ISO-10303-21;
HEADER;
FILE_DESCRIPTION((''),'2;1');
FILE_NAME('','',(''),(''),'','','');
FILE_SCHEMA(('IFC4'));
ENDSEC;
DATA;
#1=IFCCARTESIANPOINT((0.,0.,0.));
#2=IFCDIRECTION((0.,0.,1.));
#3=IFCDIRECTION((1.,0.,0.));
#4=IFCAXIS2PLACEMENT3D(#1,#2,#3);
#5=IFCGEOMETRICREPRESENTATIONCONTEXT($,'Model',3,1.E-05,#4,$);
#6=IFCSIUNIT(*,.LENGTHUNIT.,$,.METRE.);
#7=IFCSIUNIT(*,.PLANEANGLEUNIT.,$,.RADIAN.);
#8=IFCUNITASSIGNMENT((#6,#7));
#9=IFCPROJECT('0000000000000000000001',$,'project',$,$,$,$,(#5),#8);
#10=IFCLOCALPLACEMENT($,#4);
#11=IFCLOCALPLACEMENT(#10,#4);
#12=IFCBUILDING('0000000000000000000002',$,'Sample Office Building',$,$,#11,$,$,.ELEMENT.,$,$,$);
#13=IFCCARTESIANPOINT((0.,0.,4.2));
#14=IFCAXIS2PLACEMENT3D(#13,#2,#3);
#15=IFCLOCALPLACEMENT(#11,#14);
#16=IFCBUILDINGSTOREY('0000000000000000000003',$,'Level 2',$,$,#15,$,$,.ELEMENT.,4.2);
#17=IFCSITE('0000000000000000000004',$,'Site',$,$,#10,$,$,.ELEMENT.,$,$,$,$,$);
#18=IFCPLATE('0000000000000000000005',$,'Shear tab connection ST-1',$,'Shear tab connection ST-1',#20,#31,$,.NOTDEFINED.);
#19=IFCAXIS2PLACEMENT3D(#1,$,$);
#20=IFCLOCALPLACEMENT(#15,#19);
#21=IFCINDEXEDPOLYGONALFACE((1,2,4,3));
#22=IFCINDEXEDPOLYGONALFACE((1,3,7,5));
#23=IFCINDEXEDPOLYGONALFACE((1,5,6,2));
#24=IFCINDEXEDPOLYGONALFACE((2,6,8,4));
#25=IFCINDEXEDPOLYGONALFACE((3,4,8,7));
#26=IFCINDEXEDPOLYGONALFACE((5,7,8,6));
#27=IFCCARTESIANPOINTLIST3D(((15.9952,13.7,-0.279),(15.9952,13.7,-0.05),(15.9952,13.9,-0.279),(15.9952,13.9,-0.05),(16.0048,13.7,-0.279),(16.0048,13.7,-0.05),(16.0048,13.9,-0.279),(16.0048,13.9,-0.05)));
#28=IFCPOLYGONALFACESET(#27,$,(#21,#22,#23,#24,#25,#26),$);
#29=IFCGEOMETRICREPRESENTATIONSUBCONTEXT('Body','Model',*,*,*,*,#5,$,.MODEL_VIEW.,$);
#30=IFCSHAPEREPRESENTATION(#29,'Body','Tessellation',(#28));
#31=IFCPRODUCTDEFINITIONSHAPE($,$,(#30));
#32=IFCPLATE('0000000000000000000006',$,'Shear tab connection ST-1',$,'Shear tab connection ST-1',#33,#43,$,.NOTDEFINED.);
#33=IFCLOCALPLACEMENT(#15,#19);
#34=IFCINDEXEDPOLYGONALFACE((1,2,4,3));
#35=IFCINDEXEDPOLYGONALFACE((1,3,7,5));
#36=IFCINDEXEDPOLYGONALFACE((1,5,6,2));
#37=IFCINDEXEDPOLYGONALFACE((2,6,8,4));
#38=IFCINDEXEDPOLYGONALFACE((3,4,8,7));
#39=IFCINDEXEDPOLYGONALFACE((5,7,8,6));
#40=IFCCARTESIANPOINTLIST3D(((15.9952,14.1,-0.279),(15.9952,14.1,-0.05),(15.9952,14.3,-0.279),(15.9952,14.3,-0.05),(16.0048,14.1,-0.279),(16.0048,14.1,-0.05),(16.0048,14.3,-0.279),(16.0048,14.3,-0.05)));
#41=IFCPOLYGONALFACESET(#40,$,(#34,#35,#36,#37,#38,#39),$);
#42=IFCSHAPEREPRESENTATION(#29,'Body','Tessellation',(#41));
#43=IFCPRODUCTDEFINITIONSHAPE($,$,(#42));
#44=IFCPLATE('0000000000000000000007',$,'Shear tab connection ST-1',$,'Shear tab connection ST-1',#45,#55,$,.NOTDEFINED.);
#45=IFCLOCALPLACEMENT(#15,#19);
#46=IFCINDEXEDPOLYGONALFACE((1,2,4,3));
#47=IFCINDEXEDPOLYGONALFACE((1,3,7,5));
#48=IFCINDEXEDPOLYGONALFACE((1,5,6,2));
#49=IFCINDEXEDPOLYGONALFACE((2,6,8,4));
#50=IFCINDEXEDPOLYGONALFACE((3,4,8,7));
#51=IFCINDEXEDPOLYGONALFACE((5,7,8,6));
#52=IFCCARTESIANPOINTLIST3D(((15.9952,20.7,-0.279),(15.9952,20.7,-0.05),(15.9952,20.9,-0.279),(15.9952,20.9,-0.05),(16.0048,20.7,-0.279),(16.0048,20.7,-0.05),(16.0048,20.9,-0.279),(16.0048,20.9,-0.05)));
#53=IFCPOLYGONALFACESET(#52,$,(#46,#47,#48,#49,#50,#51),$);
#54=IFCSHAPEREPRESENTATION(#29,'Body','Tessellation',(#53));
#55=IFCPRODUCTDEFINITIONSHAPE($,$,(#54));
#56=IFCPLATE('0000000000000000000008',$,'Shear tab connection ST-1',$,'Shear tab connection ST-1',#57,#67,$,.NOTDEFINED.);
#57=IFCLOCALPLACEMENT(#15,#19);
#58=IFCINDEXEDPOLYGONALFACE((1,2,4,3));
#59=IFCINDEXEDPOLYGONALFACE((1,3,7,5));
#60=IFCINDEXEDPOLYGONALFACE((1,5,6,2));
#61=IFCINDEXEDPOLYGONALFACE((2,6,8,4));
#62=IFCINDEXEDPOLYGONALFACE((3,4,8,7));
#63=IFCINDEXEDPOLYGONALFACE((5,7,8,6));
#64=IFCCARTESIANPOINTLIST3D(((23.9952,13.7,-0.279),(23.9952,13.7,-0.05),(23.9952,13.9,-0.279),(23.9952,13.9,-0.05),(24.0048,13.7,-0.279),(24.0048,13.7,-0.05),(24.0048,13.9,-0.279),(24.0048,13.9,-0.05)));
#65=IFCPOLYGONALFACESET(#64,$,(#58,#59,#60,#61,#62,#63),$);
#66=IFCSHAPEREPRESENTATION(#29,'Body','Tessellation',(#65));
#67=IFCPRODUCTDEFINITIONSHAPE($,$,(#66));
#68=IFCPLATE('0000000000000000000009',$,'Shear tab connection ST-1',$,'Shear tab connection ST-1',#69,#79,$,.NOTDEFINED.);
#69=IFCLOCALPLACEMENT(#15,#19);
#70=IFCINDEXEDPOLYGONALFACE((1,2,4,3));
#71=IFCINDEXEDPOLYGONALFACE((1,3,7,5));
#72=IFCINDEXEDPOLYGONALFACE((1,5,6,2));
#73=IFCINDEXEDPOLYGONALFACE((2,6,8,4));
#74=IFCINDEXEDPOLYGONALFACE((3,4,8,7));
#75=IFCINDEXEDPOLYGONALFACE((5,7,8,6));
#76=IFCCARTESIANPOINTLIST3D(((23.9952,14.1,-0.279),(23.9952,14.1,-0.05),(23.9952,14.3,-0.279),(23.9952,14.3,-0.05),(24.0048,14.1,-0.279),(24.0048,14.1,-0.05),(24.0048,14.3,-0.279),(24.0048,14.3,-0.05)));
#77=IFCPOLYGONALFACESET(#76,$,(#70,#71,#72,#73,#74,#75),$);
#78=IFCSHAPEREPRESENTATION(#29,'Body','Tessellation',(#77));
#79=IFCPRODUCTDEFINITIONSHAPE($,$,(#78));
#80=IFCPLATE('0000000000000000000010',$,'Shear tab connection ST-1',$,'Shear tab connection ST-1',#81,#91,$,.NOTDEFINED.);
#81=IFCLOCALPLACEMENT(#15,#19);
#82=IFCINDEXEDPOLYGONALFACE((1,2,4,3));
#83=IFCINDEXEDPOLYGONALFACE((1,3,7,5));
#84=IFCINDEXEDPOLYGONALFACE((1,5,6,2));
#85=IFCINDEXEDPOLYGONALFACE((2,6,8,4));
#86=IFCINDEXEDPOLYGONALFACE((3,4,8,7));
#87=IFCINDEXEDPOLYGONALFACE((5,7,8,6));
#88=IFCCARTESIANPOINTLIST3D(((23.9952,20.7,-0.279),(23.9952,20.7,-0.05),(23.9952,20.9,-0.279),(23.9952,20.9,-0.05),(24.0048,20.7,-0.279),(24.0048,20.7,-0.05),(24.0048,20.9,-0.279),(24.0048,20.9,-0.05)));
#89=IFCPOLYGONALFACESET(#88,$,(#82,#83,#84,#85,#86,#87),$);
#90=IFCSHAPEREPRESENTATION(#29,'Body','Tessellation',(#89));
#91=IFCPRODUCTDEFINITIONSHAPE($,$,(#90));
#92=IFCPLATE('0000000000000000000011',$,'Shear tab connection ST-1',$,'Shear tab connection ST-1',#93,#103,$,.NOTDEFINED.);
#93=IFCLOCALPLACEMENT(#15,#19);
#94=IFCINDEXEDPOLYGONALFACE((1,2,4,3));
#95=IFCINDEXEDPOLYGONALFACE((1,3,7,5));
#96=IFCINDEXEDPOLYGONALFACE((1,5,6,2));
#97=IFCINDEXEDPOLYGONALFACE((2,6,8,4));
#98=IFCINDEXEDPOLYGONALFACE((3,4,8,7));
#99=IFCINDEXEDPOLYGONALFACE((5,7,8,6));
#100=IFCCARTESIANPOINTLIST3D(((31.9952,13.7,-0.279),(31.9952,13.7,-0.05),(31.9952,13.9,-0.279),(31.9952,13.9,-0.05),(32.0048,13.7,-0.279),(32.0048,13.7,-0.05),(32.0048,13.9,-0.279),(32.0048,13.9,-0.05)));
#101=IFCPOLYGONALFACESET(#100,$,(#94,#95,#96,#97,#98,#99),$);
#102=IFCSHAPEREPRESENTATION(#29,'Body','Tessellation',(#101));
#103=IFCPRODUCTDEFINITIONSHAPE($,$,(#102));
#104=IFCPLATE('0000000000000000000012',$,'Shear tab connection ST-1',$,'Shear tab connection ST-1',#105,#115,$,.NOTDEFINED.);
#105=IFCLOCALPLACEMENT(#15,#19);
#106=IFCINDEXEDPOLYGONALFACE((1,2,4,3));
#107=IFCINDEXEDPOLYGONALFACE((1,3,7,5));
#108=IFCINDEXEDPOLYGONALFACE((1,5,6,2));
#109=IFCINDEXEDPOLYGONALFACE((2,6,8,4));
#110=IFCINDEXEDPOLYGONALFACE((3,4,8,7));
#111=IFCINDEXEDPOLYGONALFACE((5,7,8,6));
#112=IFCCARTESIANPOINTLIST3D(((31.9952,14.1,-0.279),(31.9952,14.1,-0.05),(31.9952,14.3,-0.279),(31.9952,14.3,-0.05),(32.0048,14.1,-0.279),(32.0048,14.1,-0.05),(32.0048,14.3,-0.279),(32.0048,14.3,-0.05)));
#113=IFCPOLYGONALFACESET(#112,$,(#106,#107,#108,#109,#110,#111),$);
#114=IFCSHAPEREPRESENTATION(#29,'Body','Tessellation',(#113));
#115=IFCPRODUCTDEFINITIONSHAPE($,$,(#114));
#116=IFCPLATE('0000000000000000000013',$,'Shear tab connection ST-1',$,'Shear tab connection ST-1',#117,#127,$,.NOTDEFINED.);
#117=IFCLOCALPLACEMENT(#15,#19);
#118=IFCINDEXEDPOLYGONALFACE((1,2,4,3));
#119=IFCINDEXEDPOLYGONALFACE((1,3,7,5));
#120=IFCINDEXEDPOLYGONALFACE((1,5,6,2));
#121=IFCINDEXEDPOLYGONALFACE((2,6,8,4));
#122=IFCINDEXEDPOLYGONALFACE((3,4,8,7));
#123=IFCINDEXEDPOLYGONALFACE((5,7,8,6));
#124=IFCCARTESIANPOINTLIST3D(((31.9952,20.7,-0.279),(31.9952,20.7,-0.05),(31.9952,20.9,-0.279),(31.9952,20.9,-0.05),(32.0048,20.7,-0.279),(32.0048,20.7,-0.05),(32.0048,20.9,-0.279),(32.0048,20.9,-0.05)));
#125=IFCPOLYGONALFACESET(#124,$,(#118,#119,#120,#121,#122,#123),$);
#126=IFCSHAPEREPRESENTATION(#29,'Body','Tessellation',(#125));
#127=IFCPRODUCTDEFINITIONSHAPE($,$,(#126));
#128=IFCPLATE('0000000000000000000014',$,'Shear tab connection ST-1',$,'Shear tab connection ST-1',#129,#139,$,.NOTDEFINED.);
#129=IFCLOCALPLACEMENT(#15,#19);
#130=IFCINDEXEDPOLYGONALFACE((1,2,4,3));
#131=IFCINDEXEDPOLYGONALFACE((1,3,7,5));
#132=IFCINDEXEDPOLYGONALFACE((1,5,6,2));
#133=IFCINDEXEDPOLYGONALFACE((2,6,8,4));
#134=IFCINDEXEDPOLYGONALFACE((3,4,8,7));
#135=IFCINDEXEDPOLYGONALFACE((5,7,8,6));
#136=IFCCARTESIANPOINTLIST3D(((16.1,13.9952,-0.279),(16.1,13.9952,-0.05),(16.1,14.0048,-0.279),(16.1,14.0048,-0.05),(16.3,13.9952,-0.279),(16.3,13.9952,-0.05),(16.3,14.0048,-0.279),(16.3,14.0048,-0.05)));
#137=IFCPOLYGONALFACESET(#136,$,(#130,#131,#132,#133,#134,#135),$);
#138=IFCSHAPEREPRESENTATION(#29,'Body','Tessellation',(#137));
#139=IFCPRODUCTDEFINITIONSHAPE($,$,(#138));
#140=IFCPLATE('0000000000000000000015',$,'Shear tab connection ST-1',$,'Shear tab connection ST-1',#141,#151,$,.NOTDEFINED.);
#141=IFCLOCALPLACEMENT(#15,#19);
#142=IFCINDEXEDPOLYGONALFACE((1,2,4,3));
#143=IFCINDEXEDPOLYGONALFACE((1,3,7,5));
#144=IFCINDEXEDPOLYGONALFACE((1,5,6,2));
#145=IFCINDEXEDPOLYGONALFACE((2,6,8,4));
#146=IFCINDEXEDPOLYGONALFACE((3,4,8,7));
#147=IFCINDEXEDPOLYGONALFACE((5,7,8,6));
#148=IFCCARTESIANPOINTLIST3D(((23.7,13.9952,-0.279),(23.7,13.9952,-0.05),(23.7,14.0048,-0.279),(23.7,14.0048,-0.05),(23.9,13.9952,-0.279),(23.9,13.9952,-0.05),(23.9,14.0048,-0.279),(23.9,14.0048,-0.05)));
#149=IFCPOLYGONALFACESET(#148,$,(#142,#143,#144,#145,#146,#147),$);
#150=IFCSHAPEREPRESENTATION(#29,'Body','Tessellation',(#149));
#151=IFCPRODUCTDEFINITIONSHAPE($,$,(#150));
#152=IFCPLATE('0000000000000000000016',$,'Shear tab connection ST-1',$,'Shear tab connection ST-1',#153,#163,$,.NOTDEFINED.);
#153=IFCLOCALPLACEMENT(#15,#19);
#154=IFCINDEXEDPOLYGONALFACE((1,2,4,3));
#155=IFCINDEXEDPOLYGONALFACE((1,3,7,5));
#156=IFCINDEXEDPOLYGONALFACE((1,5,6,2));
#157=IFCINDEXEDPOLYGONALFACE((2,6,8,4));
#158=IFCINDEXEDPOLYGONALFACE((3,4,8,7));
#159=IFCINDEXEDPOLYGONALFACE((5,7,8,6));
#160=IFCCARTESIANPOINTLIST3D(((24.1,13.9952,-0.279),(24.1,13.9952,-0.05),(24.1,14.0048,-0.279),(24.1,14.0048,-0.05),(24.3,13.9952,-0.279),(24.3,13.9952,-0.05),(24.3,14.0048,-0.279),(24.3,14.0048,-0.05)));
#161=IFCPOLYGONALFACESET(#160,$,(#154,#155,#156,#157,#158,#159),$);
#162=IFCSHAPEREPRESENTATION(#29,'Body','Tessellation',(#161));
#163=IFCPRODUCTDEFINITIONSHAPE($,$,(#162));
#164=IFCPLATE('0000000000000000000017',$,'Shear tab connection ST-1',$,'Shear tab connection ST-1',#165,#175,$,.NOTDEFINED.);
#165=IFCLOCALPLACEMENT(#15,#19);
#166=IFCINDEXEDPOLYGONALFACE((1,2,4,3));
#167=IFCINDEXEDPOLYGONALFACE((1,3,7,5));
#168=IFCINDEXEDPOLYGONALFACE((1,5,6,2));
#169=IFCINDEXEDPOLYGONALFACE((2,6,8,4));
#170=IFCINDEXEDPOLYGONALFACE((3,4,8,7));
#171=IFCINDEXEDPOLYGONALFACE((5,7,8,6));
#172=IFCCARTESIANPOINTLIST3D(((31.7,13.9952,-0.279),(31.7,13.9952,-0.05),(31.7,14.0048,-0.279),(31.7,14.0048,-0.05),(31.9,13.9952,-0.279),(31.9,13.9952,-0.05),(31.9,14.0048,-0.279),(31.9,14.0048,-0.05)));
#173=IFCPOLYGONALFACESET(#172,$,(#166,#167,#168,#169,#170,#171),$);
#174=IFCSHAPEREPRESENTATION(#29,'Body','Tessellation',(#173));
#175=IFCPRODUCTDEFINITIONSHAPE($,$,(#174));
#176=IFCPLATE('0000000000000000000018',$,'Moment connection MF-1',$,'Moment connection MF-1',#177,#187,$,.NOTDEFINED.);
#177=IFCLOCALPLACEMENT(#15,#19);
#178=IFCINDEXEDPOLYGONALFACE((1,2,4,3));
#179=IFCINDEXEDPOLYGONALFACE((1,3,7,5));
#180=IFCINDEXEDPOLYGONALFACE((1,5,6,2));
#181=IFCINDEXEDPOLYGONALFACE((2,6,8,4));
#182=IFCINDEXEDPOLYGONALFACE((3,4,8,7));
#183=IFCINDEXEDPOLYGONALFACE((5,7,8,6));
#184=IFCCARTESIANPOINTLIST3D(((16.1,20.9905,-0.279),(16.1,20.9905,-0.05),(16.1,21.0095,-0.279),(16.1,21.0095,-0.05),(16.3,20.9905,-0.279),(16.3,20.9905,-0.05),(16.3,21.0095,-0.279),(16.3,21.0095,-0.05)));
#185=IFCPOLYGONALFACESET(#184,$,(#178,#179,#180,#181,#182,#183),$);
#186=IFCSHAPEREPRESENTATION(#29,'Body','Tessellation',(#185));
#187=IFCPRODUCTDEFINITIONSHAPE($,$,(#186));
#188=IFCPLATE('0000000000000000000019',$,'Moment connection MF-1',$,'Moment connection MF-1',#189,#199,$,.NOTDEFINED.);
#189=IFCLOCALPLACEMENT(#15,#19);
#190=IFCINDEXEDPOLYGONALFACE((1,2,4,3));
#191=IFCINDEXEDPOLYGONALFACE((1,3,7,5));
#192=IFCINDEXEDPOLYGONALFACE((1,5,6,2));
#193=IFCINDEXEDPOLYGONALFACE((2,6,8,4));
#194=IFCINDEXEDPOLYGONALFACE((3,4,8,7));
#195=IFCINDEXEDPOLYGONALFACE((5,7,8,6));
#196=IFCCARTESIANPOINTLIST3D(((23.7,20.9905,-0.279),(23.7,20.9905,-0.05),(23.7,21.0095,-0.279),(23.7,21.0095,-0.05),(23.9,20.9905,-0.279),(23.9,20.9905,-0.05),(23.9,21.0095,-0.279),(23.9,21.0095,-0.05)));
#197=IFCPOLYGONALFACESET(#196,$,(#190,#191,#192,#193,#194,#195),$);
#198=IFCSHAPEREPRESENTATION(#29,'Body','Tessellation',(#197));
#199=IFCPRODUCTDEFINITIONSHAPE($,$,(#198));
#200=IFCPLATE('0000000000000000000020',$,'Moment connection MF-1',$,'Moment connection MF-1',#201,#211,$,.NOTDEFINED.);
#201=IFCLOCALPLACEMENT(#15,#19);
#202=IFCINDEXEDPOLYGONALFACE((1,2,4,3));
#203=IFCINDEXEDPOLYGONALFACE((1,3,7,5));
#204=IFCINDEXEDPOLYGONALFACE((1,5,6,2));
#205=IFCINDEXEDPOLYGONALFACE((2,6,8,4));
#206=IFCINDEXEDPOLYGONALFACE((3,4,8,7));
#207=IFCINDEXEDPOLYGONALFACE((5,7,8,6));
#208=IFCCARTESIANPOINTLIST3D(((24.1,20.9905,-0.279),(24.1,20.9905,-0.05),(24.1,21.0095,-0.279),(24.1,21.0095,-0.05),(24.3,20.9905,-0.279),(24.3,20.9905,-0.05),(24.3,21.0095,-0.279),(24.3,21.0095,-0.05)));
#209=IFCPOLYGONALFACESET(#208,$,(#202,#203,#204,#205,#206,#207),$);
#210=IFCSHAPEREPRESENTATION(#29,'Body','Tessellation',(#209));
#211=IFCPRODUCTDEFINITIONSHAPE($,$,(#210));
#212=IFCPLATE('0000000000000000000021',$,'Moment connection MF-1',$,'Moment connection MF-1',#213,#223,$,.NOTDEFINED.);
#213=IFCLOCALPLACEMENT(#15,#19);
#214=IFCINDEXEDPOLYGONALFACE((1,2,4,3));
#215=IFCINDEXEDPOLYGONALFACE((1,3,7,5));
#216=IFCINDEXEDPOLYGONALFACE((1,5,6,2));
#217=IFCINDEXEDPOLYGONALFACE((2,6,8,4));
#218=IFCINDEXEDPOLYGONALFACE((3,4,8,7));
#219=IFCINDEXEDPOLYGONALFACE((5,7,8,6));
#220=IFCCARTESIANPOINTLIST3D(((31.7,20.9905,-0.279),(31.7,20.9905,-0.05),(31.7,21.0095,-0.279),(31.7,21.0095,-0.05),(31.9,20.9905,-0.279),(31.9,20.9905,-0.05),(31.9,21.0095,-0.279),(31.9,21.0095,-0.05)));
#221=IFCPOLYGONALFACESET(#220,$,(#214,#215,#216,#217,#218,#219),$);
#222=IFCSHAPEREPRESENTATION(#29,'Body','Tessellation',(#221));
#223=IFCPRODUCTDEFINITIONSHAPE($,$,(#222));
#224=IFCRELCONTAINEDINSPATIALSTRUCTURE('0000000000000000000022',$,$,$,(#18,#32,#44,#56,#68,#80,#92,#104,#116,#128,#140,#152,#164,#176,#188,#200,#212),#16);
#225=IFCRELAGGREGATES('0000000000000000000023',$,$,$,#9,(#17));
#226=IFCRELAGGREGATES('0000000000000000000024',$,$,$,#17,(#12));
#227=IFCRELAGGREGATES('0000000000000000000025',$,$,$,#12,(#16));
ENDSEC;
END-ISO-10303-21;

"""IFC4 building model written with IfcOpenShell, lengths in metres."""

from ifc_helpers import new_model, si_unit, frame, origin_with_axes, place, context, subcontext, project, spatial, rectangle, extrude, element, save


model = new_model("IFC4")

# Units and contexts
model_context = context("Model", 3, precision=1e-05, world=origin_with_axes())
body_context = subcontext(model_context, "Body", "Model", "MODEL_VIEW")
ifc_project = project(units=[si_unit("LENGTHUNIT", "METRE"), si_unit("PLANEANGLEUNIT", "RADIAN")], contexts=[model_context])

# Site, building, storey
site_placement = place(None, origin_with_axes())
site = spatial("IfcSite", under=ifc_project, at=site_placement, Name="Site", CompositionType="ELEMENT")
building_placement = place(site_placement, origin_with_axes())
building = spatial("IfcBuilding", under=site, at=building_placement, Name="Sample Office Building", CompositionType="ELEMENT")
storey_placement = place(building_placement, frame((0.0, 0.0, 4.2), z_axis=(0.0, 0.0, 1.0), x_axis=(1.0, 0.0, 0.0)))
storey = spatial("IfcBuildingStorey", under=building, at=storey_placement, Name="Level 2", CompositionType="ELEMENT", Elevation=4.2)

# Plates
for number, where, z_axis, x_axis, name in (
    (1, (16.0, 13.8, 3.921), (0.0, 0.0, 1.0), (1.0, 0.0, 0.0), "Shear tab connection ST-1"),
    (2, (16.0, 14.2, 3.921), (0.0, 0.0, 1.0), (1.0, 0.0, 0.0), "Shear tab connection ST-1"),
):
    element("IfcPlate", number, at=place(None, frame(where, z_axis=z_axis, x_axis=x_axis)), inside=storey, Name=name, ObjectType="Shear tab connection ST-1", PredefinedType="NOTDEFINED", context=body_context, shape_type="SweptSolid", body=[
        extrude(rectangle(XDim=0.0095, YDim=0.2), None, (0.0, 0.0, 1.0), 0.229),
    ])
plate_1_placement = place(None, frame((16.0, 20.8, 3.921), z_axis=(0.0, 0.0, 1.0), x_axis=(1.0, 0.0, 0.0)))
element("IfcPlate", 3, at=plate_1_placement, inside=storey, Name="Shear tab connection ST-1", ObjectType="Shear tab connection ST-1", PredefinedType="NOTDEFINED", context=body_context, shape_type="SweptSolid", body=[
    extrude(rectangle(XDim=0.0095, YDim=0.2), None, (0.0, 0.0, 1.0), 0.229),
])
for number, where, z_axis, x_axis, name in (
    (4, (24.0, 13.8, 3.921), (0.0, 0.0, 1.0), (1.0, 0.0, 0.0), "Shear tab connection ST-1"),
    (5, (24.0, 14.2, 3.921), (0.0, 0.0, 1.0), (1.0, 0.0, 0.0), "Shear tab connection ST-1"),
):
    element("IfcPlate", number, at=place(None, frame(where, z_axis=z_axis, x_axis=x_axis)), inside=storey, Name=name, ObjectType="Shear tab connection ST-1", PredefinedType="NOTDEFINED", context=body_context, shape_type="SweptSolid", body=[
        extrude(rectangle(XDim=0.0095, YDim=0.2), None, (0.0, 0.0, 1.0), 0.229),
    ])
plate_2_placement = place(None, frame((24.0, 20.8, 3.921), z_axis=(0.0, 0.0, 1.0), x_axis=(1.0, 0.0, 0.0)))
element("IfcPlate", 6, at=plate_2_placement, inside=storey, Name="Shear tab connection ST-1", ObjectType="Shear tab connection ST-1", PredefinedType="NOTDEFINED", context=body_context, shape_type="SweptSolid", body=[
    extrude(rectangle(XDim=0.0095, YDim=0.2), None, (0.0, 0.0, 1.0), 0.229),
])
for number, where, z_axis, x_axis, name in (
    (7, (32.0, 13.8, 3.921), (0.0, 0.0, 1.0), (1.0, 0.0, 0.0), "Shear tab connection ST-1"),
    (8, (32.0, 14.2, 3.921), (0.0, 0.0, 1.0), (1.0, 0.0, 0.0), "Shear tab connection ST-1"),
):
    element("IfcPlate", number, at=place(None, frame(where, z_axis=z_axis, x_axis=x_axis)), inside=storey, Name=name, ObjectType="Shear tab connection ST-1", PredefinedType="NOTDEFINED", context=body_context, shape_type="SweptSolid", body=[
        extrude(rectangle(XDim=0.0095, YDim=0.2), None, (0.0, 0.0, 1.0), 0.229),
    ])
plate_3_placement = place(None, frame((32.0, 20.8, 3.921), z_axis=(0.0, 0.0, 1.0), x_axis=(1.0, 0.0, 0.0)))
element("IfcPlate", 9, at=plate_3_placement, inside=storey, Name="Shear tab connection ST-1", ObjectType="Shear tab connection ST-1", PredefinedType="NOTDEFINED", context=body_context, shape_type="SweptSolid", body=[
    extrude(rectangle(XDim=0.0095, YDim=0.2), None, (0.0, 0.0, 1.0), 0.229),
])
for number, where, z_axis, x_axis, name in (
    (10, (16.2, 14.0, 3.921), (0.0, 0.0, 1.0), (1.0, 0.0, 0.0), "Shear tab connection ST-1"),
    (11, (23.8, 14.0, 3.921), (0.0, 0.0, 1.0), (1.0, 0.0, 0.0), "Shear tab connection ST-1"),
    (12, (24.2, 14.0, 3.921), (0.0, 0.0, 1.0), (1.0, 0.0, 0.0), "Shear tab connection ST-1"),
    (13, (31.8, 14.0, 3.921), (0.0, 0.0, 1.0), (1.0, 0.0, 0.0), "Shear tab connection ST-1"),
):
    element("IfcPlate", number, at=place(None, frame(where, z_axis=z_axis, x_axis=x_axis)), inside=storey, Name=name, ObjectType="Shear tab connection ST-1", PredefinedType="NOTDEFINED", context=body_context, shape_type="SweptSolid", body=[
        extrude(rectangle(XDim=0.2, YDim=0.0095), None, (0.0, 0.0, 1.0), 0.229),
    ])
for number, where, z_axis, x_axis, name in (
    (14, (16.2, 21.0, 3.921), (0.0, 0.0, 1.0), (1.0, 0.0, 0.0), "Moment connection MF-1"),
    (15, (23.8, 21.0, 3.921), (0.0, 0.0, 1.0), (1.0, 0.0, 0.0), "Moment connection MF-1"),
    (16, (24.2, 21.0, 3.921), (0.0, 0.0, 1.0), (1.0, 0.0, 0.0), "Moment connection MF-1"),
    (17, (31.8, 21.0, 3.921), (0.0, 0.0, 1.0), (1.0, 0.0, 0.0), "Moment connection MF-1"),
):
    element("IfcPlate", number, at=place(None, frame(where, z_axis=z_axis, x_axis=x_axis)), inside=storey, Name=name, ObjectType="Moment connection MF-1", PredefinedType="NOTDEFINED", context=body_context, shape_type="SweptSolid", body=[
        extrude(rectangle(XDim=0.2, YDim=0.019), None, (0.0, 0.0, 1.0), 0.229),
    ])

save(model, "model.ifc")
